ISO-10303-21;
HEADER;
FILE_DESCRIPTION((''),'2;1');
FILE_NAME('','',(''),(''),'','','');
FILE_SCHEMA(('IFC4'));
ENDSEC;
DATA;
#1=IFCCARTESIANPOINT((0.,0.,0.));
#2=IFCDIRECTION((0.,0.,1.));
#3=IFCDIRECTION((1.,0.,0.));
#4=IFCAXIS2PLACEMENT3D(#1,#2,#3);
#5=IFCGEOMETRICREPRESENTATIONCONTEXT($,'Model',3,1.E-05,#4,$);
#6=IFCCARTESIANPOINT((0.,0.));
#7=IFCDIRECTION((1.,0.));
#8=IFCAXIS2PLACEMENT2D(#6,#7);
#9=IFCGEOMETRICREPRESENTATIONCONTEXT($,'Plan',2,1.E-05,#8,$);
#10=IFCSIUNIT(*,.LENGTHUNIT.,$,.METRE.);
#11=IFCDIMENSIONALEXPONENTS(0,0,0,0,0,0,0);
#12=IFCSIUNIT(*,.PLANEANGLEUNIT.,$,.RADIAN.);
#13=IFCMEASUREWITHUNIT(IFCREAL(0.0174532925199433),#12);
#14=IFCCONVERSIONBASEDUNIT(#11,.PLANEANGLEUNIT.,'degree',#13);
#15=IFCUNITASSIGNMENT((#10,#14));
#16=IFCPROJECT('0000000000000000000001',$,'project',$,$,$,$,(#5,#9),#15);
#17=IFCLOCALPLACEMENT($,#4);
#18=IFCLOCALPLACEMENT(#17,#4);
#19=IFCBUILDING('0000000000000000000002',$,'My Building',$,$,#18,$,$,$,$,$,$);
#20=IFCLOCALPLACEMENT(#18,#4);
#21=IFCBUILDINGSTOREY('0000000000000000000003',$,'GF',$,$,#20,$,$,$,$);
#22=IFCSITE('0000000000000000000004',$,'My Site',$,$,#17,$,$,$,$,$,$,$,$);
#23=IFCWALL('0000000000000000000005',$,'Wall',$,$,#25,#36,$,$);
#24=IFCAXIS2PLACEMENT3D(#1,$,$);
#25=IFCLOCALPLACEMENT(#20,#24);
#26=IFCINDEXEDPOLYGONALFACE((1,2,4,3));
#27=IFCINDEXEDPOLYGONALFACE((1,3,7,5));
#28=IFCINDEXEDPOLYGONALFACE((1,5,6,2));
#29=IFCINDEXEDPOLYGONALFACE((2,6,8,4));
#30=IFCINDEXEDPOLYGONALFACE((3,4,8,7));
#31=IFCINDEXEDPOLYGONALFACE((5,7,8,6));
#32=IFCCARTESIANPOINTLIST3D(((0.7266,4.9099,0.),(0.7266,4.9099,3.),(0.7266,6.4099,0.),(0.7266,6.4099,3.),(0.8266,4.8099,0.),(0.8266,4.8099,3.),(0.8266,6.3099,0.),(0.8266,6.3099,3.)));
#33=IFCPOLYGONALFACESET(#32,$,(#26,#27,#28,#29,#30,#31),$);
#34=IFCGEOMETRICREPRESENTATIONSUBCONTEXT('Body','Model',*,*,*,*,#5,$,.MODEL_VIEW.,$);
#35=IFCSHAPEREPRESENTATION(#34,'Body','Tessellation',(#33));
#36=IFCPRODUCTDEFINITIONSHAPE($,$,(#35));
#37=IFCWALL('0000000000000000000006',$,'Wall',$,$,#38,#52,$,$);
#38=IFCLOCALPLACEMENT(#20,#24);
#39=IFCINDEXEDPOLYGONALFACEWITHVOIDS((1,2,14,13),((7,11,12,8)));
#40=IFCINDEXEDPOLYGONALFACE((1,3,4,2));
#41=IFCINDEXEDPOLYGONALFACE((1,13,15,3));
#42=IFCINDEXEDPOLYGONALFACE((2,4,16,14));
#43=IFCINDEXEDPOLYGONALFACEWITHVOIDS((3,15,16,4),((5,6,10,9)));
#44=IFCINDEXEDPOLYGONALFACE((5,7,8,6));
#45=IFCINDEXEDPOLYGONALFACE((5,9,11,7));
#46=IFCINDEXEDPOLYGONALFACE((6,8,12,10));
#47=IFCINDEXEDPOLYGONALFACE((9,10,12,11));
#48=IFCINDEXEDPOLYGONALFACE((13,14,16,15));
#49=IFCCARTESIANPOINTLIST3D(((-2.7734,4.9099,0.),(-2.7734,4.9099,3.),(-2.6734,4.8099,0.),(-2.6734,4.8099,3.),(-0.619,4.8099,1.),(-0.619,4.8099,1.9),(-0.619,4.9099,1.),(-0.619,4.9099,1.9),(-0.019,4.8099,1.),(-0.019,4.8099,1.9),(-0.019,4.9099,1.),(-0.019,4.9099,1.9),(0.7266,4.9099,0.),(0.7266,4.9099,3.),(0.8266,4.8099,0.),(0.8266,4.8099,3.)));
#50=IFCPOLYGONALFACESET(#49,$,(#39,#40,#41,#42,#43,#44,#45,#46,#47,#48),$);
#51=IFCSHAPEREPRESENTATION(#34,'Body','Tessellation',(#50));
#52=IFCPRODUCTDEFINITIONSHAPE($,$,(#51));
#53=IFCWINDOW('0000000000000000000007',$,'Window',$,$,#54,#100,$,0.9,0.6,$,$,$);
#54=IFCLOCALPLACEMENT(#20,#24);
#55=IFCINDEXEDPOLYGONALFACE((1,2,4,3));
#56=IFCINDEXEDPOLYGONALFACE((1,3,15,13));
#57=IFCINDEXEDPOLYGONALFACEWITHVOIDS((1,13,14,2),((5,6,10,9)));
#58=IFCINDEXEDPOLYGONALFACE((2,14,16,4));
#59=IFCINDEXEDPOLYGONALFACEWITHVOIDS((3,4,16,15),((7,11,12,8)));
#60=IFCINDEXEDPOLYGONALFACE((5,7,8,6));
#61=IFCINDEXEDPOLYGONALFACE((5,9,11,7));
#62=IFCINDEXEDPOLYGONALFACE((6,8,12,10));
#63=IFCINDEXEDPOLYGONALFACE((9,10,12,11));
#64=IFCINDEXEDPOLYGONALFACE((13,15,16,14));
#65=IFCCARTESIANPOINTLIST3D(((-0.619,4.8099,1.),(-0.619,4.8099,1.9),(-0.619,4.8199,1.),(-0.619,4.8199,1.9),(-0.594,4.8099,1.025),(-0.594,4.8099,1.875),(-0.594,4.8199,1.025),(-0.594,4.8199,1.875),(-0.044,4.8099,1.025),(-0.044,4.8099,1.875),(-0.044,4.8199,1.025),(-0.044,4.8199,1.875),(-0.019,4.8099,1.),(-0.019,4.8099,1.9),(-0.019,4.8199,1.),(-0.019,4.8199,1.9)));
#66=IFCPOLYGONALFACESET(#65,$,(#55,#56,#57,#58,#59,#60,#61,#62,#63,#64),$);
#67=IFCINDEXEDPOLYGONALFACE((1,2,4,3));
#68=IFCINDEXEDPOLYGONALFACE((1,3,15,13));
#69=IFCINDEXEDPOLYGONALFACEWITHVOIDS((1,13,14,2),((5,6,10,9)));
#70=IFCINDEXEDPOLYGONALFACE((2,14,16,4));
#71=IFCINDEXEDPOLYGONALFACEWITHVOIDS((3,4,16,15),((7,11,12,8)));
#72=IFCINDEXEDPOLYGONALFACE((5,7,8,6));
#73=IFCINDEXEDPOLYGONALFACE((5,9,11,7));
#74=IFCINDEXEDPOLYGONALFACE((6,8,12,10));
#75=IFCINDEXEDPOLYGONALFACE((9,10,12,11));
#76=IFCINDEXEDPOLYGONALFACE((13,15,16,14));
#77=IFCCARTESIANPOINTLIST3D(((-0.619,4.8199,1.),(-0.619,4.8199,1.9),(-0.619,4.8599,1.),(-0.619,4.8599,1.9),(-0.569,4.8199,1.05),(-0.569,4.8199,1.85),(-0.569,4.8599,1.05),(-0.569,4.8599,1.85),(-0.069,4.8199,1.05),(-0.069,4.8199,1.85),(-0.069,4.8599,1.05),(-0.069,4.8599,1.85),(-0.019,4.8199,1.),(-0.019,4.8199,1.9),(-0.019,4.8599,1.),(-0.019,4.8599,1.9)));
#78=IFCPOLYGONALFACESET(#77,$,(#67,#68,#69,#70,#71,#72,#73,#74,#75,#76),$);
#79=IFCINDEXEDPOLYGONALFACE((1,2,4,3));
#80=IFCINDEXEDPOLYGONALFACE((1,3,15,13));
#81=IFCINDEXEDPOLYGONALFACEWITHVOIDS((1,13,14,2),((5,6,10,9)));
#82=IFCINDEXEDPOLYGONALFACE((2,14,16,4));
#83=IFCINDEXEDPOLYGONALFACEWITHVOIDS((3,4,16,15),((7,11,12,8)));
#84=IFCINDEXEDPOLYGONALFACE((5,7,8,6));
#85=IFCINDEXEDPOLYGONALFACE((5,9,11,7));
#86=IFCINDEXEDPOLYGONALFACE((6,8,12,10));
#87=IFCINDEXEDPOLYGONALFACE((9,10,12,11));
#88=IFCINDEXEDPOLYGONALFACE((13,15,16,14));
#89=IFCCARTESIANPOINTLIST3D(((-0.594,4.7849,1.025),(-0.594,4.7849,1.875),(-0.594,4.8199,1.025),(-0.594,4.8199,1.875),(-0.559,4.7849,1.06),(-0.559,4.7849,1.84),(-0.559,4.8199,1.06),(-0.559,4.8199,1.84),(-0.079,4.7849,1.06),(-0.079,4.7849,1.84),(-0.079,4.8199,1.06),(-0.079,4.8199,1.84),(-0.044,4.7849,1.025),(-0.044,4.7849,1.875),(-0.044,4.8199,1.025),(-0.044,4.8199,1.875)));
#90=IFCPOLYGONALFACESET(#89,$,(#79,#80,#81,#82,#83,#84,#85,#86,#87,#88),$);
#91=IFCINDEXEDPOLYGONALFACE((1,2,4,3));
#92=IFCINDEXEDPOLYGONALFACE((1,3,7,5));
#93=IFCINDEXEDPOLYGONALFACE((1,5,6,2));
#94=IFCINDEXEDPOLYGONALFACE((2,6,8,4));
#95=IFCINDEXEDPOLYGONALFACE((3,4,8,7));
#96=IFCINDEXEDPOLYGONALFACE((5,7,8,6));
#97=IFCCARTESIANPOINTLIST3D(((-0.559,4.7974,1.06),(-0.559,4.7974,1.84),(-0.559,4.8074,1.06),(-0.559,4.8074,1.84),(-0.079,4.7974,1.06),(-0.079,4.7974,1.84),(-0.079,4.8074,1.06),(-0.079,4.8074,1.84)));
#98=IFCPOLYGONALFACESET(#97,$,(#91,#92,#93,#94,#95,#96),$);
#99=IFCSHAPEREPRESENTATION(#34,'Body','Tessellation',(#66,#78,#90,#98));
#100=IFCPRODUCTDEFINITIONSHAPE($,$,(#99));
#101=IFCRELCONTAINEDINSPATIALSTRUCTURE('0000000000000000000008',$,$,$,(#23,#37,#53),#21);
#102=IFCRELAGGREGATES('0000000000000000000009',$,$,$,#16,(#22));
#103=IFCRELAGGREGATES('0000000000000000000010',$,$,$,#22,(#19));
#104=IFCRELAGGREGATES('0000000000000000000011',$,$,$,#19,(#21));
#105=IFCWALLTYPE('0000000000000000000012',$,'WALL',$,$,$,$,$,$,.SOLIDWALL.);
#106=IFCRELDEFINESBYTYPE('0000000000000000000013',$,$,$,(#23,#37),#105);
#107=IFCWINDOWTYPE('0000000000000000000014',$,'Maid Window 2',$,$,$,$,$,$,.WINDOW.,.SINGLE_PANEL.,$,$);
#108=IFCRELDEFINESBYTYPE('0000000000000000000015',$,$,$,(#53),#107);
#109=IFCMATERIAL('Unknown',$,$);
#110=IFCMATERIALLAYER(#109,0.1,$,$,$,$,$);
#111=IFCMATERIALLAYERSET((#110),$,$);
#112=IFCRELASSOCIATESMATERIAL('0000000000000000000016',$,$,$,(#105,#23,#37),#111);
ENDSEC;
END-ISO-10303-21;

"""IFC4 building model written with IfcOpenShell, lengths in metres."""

from ifc_helpers import new_model, entity, si_unit, converted_unit, frame, origin_with_axes, origin_2d_with_axis, place, context, subcontext, project, spatial, line, indexed_curve, outline, extrude, shape, source, transform, mapped, material, layer, layer_set, layer_usage, type_object, type_shapes, element, fill, save


model = new_model("IFC4")

# Units and contexts
model_context = context("Model", 3, precision=1e-05, world=origin_with_axes())
plan_context = context("Plan", 2, precision=1e-05, world=origin_2d_with_axis())
body_context_1 = subcontext(model_context, "Body", "Model", "MODEL_VIEW")
body_context_2 = subcontext(plan_context, "Body", "Plan", "PLAN_VIEW")
ifc_project = project(units=[si_unit("LENGTHUNIT", "METRE"), converted_unit("PLANEANGLEUNIT", "degree", entity("IfcReal", 0.0174532925199433), si_unit("PLANEANGLEUNIT", "RADIAN"), dimensions=[0, 0, 0, 0, 0, 0, 0])], contexts=[model_context, plan_context])

# Site, building, storey
site_placement = place(None, origin_with_axes())
site = spatial("IfcSite", under=ifc_project, at=site_placement, Name="My Site")
building_placement = place(site_placement, origin_with_axes())
building = spatial("IfcBuilding", under=site, at=building_placement, Name="My Building")
storey_placement = place(building_placement, origin_with_axes())
storey = spatial("IfcBuildingStorey", under=building, at=storey_placement, Name="GF")

# Shared definitions
ifc_material = material(Name="Unknown")

# Wall
ifc_layer_1 = layer(ifc_material, 0.1)
ifc_layer_set_1 = layer_set([ifc_layer_1])
wall_type = type_object("IfcWallType", Name="WALL", PredefinedType="SOLIDWALL", material=ifc_layer_set_1)
ifc_layer_usage_1 = layer_usage(ifc_layer_set_1, "AXIS2", "POSITIVE", 0.0)
wall_1_placement = place(storey_placement, frame((0.7266, 6.4099, 0.0), z_axis=(0.0, 0.0, 1.0), x_axis=(0.0, -1.0, 0.0)))
element("IfcWall", 1, at=wall_1_placement, inside=storey, type_object=wall_type, material=ifc_layer_usage_1, Name="Wall", context=body_context_1, shape_type="SweptSolid", body=[
    extrude(outline(indexed_curve([(0.0, 0.0), (0.1, 0.1), (1.6, 0.1), (1.5, 0.0)], segments=[line(1, 2, 3, 4, 1)])), origin_with_axes(), (0.0, 0.0, 1.0), 3.0),
])

# Wall, opening, window
ifc_layer_usage_2 = layer_usage(ifc_layer_set_1, "AXIS2", "POSITIVE", 0.0)
wall_2_placement = place(storey_placement, frame((0.7266, 4.9099, 0.0), z_axis=(0.0, 0.0, 1.0), x_axis=(-1.0, 0.0, 0.0)))
wall_2 = element("IfcWall", 2, at=wall_2_placement, inside=storey, type_object=wall_type, material=ifc_layer_usage_2, Name="Wall", context=body_context_1, shape_type="SweptSolid", body=[
    extrude(outline(indexed_curve([(0.0, 0.0), (-0.1, 0.1), (3.4, 0.1), (3.5, 0.0)], segments=[line(1, 2, 3, 4, 1)])), origin_with_axes(), (0.0, 0.0, 1.0), 3.0),
])
shared_shape_1 = source(origin_with_axes(), body_context_1, "Body", "SweptSolid", [
    extrude(outline(indexed_curve([(0.0, 0.0), (0.6, 0.0), (0.6, 0.9), (0.0, 0.9)], segments=[line(1, 2, 3, 4, 1)])), frame((0.0, -0.6, 0.0), z_axis=(0.0, -1.0, 0.0), x_axis=(1.0, 0.0, 0.0)), (0.0, 0.0, -1.0), 1.2),
])
opening_1_placement = place(wall_2_placement, frame((0.7456, 0.0, 1.0), z_axis=(0.0, 0.0, 1.0), x_axis=(1.0, 0.0, 0.0)))
opening_1 = element("IfcOpeningElement", 3, at=opening_1_placement, cuts=wall_2, PredefinedType="OPENING", context=body_context_1, shape_type="MappedRepresentation", body=[
    mapped(shared_shape_1, transform((0.0, 0.0, 0.0), x_axis=(1.0, 0.0, 0.0), y_axis=(0.0, 1.0, 0.0), z_axis=(0.0, 0.0, 1.0), scale=1.0)),
])
window_type_1 = type_object("IfcWindowType", Name="Maid Window 2", PartitioningType="SINGLE_PANEL", PredefinedType="WINDOW")
shared_shape_2 = source(origin_with_axes(), body_context_1, "Body", "SweptSolid", [
    extrude(outline(indexed_curve([(0.0, 0.0), (0.6, 0.0), (0.6, 0.9), (0.0, 0.9)], segments=[line(1, 2, 3, 4, 1)]), holes=[indexed_curve([(0.025, 0.025), (0.575, 0.025), (0.575, 0.875), (0.025, 0.875)], segments=[line(1, 2, 3, 4, 1)])]), frame((0.0, 0.09, 0.0), z_axis=(0.0, -1.0, 0.0), x_axis=(1.0, 0.0, 0.0)), (0.0, 0.0, -1.0), 0.01),
    extrude(outline(indexed_curve([(0.0, 0.0), (0.6, 0.0), (0.6, 0.9), (0.0, 0.9)], segments=[line(1, 2, 3, 4, 1)]), holes=[indexed_curve([(0.05, 0.05), (0.55, 0.05), (0.55, 0.85), (0.05, 0.85)], segments=[line(1, 2, 3, 4, 1)])]), frame((0.0, 0.05, 0.0), z_axis=(0.0, -1.0, 0.0), x_axis=(1.0, 0.0, 0.0)), (0.0, 0.0, -1.0), 0.04),
    extrude(outline(indexed_curve([(0.0, 0.0), (0.55, 0.0), (0.55, 0.85), (0.0, 0.85)], segments=[line(1, 2, 3, 4, 1)]), holes=[indexed_curve([(0.035, 0.035), (0.515, 0.035), (0.515, 0.815), (0.035, 0.815)], segments=[line(1, 2, 3, 4, 1)])]), frame((0.025, 0.09, 0.025), z_axis=(0.0, -1.0, 0.0), x_axis=(1.0, 0.0, 0.0)), (0.0, 0.0, -1.0), 0.035),
    extrude(outline(indexed_curve([(0.035, 0.035), (0.515, 0.035), (0.515, 0.815), (0.035, 0.815)], segments=[line(1, 2, 3, 4, 1)])), frame((0.025, 0.1025, 0.025), z_axis=(0.0, -1.0, 0.0), x_axis=(1.0, 0.0, 0.0)), (0.0, 0.0, -1.0), 0.01),
])
shared_shape_3 = source(origin_with_axes(), body_context_2, "Body", "Curve2D", [
    entity("IfcIndexedPolyCurve", entity("IfcCartesianPointList2D", [[0.05, 0.05], [0.55, 0.05]])),
    entity("IfcIndexedPolyCurve", entity("IfcCartesianPointList2D", [[0.0, 0.1], [0.025, 0.1], [0.025, 0.09], [0.05, 0.09], [0.05, 0.05], [0.0, 0.05]]), [entity("IfcLineIndex", [1, 2, 3, 4, 5, 6, 1])]),
    entity("IfcIndexedPolyCurve", entity("IfcCartesianPointList2D", [[0.6, 0.1], [0.575, 0.1], [0.575, 0.09], [0.55, 0.09], [0.55, 0.05], [0.6, 0.05]]), [entity("IfcLineIndex", [1, 2, 3, 4, 5, 6, 1])]),
    entity("IfcIndexedPolyCurve", entity("IfcCartesianPointList2D", [[0.025, 0.09], [0.06, 0.09], [0.06, 0.125], [0.025, 0.125]]), [entity("IfcLineIndex", [1, 2, 3, 4, 1])]),
    entity("IfcIndexedPolyCurve", entity("IfcCartesianPointList2D", [[0.575, 0.09], [0.54, 0.09], [0.54, 0.125], [0.575, 0.125]]), [entity("IfcLineIndex", [1, 2, 3, 4, 1])]),
    entity("IfcIndexedPolyCurve", entity("IfcCartesianPointList2D", [[0.06, 0.09], [0.54, 0.09]])),
    entity("IfcIndexedPolyCurve", entity("IfcCartesianPointList2D", [[0.06, 0.125], [0.54, 0.125]])),
    entity("IfcIndexedPolyCurve", entity("IfcCartesianPointList2D", [[0.06, 0.1075], [0.54, 0.1075]])),
])
type_shapes(window_type_1, [shared_shape_2, shared_shape_3])
window_1_placement = place(opening_1_placement, frame((0.0, 0.0, 0.0), z_axis=(0.0, 0.0, 1.0), x_axis=(1.0, 0.0, 0.0)))
window_1 = element("IfcWindow", 4, at=window_1_placement, inside=storey, type_object=window_type_1, Name="Window", OverallHeight=0.9, OverallWidth=0.6, shapes=[
    shape(body_context_1, "Body", "MappedRepresentation", [mapped(shared_shape_2, transform((0.0, 0.0, 0.0), x_axis=(1.0, 0.0, 0.0), y_axis=(0.0, 1.0, 0.0), z_axis=(0.0, 0.0, 1.0), scale=1.0))]),
    shape(body_context_2, "Body", "MappedRepresentation", [mapped(shared_shape_3, transform((0.0, 0.0, 0.0), x_axis=(1.0, 0.0, 0.0), y_axis=(0.0, 1.0, 0.0), z_axis=(0.0, 0.0, 1.0), scale=1.0))]),
])
fill(opening_1, window_1)

save(model, "model.ifc")
